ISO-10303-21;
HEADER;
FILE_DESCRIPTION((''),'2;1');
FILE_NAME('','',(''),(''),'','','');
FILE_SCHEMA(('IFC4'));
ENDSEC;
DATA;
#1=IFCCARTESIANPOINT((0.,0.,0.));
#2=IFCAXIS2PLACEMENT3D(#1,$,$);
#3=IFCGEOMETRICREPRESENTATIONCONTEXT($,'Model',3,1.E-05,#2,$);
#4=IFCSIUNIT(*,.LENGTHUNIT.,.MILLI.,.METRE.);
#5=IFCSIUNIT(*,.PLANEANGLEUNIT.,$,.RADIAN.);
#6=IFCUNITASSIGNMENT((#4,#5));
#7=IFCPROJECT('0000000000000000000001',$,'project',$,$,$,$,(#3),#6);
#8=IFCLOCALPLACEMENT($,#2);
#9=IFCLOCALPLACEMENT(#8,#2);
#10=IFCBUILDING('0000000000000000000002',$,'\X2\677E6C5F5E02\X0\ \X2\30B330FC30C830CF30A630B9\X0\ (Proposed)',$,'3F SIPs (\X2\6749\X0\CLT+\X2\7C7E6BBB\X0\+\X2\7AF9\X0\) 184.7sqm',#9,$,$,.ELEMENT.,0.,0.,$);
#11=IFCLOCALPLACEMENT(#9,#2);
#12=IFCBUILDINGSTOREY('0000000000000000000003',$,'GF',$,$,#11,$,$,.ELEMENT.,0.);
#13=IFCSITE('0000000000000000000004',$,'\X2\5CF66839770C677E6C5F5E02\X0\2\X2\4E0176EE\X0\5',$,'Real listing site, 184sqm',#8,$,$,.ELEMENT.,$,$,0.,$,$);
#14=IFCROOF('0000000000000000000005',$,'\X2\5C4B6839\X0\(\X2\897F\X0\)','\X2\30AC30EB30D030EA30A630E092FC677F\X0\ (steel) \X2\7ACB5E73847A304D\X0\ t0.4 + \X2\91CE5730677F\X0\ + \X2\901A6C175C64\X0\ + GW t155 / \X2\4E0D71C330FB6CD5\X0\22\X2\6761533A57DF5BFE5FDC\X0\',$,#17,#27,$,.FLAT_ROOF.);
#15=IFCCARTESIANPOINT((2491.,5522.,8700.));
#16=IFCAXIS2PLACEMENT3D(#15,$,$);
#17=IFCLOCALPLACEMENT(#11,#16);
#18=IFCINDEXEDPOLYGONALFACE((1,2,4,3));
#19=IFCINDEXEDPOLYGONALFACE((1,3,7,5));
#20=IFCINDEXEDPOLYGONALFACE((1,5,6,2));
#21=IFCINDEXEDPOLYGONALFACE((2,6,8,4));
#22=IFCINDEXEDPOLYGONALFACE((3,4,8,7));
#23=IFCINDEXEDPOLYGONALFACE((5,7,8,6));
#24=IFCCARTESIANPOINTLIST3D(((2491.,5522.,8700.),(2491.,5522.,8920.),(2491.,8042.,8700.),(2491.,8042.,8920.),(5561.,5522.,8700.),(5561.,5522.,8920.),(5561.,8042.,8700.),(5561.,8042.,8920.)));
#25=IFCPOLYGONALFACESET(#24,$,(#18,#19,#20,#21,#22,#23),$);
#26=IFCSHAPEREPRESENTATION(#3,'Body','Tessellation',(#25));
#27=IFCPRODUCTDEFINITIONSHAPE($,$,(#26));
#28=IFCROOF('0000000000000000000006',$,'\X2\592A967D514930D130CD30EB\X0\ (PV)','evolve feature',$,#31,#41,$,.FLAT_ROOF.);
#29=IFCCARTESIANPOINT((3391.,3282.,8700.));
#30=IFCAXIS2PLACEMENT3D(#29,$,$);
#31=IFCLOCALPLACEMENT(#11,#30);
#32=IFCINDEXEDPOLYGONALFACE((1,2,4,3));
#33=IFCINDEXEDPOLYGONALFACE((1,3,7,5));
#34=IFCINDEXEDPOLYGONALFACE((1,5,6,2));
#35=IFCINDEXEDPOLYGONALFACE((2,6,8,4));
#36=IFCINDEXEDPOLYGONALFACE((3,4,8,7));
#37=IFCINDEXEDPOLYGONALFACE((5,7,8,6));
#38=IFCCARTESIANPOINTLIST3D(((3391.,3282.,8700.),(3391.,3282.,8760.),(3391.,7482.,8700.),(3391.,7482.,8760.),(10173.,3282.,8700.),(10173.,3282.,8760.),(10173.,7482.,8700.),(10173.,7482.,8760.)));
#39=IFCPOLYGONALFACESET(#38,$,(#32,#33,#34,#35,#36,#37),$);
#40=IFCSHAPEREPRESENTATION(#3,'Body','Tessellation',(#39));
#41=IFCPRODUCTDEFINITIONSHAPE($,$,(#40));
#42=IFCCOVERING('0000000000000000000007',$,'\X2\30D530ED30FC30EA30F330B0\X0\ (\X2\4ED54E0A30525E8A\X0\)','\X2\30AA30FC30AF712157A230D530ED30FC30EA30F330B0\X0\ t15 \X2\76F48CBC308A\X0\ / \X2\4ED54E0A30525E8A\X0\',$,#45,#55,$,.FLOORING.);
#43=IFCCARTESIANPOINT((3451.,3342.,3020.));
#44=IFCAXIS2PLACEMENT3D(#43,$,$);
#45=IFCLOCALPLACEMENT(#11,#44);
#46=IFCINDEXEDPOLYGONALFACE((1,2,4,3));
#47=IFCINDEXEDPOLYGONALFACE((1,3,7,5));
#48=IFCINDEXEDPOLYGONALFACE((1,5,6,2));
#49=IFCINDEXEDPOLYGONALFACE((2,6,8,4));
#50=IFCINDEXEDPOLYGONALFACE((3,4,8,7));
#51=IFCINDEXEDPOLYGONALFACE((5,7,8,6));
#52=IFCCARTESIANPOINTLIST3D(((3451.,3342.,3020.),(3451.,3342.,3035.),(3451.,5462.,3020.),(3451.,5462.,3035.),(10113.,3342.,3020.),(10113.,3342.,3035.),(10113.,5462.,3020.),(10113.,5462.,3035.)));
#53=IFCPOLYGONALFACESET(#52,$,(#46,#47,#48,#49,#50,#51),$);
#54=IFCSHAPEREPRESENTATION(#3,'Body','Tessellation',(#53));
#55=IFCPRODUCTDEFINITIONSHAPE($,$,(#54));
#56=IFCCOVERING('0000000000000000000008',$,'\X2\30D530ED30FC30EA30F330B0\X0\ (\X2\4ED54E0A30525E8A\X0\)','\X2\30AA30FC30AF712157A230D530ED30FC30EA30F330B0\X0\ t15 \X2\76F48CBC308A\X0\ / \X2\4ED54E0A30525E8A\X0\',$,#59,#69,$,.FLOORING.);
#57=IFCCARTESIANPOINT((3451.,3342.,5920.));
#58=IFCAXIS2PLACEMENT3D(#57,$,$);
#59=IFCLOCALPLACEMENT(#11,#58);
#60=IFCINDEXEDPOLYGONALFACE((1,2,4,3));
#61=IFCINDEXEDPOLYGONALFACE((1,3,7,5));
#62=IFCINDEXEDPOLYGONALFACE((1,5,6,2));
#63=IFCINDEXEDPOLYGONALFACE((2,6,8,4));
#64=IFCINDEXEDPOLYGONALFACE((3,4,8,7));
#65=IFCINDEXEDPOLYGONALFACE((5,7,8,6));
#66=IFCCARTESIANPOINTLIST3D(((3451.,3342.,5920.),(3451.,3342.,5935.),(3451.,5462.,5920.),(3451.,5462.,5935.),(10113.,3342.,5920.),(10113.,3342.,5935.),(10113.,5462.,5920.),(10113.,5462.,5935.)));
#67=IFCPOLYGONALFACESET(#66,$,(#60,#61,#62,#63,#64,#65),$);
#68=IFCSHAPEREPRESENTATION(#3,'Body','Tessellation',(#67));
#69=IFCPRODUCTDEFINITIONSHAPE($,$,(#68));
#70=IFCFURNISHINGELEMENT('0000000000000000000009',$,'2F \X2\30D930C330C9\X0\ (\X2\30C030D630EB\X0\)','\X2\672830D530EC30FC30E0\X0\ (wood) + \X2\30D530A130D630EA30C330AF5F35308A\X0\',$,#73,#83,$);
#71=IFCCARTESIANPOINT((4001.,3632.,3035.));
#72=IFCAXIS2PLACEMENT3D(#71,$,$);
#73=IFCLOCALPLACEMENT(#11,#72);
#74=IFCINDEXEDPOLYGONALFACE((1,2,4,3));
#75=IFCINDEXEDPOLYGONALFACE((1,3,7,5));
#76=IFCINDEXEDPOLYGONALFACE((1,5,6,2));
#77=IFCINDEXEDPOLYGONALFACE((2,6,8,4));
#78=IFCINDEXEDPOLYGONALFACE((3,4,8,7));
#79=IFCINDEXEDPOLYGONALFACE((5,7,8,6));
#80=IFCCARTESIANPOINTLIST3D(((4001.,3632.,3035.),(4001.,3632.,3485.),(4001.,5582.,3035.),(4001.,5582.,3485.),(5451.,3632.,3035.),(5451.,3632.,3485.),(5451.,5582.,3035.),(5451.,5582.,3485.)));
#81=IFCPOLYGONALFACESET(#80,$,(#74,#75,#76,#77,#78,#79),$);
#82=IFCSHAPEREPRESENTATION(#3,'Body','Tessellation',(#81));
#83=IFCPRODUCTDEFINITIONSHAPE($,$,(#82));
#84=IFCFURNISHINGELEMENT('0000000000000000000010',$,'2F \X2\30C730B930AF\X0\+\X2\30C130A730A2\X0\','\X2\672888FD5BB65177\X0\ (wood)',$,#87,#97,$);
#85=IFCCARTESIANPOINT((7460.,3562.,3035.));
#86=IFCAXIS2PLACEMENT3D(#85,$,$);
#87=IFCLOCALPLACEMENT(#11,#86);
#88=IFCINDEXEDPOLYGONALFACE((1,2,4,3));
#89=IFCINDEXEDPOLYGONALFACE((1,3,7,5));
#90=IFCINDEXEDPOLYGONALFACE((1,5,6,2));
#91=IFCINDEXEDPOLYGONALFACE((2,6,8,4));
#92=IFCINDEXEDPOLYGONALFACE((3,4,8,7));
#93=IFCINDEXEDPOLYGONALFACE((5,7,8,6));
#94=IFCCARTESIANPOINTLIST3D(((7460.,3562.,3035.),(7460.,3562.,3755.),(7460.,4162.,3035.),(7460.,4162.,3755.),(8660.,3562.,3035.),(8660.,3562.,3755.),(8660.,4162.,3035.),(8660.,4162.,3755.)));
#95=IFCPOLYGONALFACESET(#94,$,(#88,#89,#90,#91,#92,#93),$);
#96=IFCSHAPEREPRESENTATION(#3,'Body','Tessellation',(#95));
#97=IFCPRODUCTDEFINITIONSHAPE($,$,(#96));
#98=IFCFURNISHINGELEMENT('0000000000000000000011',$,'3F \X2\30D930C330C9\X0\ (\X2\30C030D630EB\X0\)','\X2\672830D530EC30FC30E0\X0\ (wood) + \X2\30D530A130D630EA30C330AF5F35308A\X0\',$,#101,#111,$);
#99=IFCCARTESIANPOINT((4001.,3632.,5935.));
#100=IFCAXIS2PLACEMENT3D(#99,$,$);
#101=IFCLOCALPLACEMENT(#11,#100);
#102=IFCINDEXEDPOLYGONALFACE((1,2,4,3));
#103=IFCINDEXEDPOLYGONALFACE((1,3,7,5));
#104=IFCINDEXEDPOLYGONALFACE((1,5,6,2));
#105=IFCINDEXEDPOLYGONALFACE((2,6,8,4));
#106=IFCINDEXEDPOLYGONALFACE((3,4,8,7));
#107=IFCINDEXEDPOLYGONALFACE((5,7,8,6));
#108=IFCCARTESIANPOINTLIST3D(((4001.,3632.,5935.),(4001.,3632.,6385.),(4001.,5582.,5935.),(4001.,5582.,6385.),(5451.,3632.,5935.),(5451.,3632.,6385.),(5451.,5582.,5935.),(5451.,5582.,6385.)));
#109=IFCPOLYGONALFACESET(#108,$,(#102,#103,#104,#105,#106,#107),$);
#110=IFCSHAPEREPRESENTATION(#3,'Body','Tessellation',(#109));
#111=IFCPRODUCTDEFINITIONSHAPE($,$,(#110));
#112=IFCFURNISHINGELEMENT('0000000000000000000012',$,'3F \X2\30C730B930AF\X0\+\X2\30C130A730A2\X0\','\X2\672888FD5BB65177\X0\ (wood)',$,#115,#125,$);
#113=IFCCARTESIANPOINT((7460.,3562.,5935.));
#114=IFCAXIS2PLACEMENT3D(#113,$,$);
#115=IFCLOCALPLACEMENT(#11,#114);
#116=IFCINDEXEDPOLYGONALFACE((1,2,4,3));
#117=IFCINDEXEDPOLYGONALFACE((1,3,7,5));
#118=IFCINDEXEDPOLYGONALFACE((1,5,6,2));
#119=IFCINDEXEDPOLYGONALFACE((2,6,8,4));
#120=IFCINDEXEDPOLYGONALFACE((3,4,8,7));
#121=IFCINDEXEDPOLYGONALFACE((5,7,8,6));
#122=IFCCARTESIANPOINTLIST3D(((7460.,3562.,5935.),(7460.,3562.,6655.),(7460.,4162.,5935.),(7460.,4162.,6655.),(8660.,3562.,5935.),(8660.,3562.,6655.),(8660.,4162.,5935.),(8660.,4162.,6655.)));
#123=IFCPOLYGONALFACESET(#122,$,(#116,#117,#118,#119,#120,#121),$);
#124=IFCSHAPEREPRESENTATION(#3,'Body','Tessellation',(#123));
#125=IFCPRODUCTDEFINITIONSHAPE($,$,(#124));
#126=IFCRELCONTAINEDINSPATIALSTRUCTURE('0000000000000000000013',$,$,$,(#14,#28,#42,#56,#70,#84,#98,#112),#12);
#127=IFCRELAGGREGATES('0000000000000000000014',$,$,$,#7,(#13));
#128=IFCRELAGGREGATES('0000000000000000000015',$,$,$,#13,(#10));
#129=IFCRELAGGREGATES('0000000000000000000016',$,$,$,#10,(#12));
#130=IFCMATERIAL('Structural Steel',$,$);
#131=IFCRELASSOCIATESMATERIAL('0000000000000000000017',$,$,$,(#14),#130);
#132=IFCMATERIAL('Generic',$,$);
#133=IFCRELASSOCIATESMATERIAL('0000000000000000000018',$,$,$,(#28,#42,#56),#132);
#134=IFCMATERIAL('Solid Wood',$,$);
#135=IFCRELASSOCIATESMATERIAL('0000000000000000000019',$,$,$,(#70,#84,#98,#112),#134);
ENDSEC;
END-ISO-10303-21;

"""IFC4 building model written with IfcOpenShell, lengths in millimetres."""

from ifc_helpers import new_model, si_unit, frame, frame_2d, origin, place, context, project, spatial, rectangle, extrude, material, element, save


model = new_model("IFC4")

# Units and contexts
model_context = context("Model", 3, precision=1e-05, world=origin())
ifc_project = project(units=[si_unit("LENGTHUNIT", "METRE", prefix="MILLI"), si_unit("PLANEANGLEUNIT", "RADIAN")], contexts=[model_context])

# Site, building, storey
site_placement = place(None, origin())
site = spatial("IfcSite", under=ifc_project, at=site_placement, Name="島根県松江市2丁目5", ObjectType="Real listing site, 184sqm", CompositionType="ELEMENT", RefElevation=0.0)
building_placement = place(site_placement, origin())
building = spatial("IfcBuilding", under=site, at=building_placement, Name="松江市 コートハウス (Proposed)", ObjectType="3F SIPs (杉CLT+籾殻+竹) 184.7sqm", CompositionType="ELEMENT", ElevationOfRefHeight=0.0, ElevationOfTerrain=0.0)
storey_placement = place(building_placement, origin())
storey = spatial("IfcBuildingStorey", under=building, at=storey_placement, Name="GF", CompositionType="ELEMENT", Elevation=0.0)

# Shared definitions
ifc_material_1 = material(Name="Solid Wood")

# Roofs
ifc_material_2 = material(Name="Structural Steel")
roof_1_placement = place(storey_placement, frame((2491.0, 5522.0, 8700.0)))
element("IfcRoof", 1, at=roof_1_placement, inside=storey, material=ifc_material_2, Name="屋根(西)", Description="ガルバリウム鋼板 (steel) 立平葺き t0.4 + 野地板 + 通気層 + GW t155 / 不燃・法22条区域対応", PredefinedType="FLAT_ROOF", context=model_context, shape_type="SweptSolid", body=[
    extrude(rectangle(XDim=3070.0, YDim=2520.0, at=frame_2d((1535.0, 1260.0))), frame((2491.0, 5522.0, 8700.0)), (0.0, 0.0, 1.0), 220.0),
])
ifc_material_3 = material(Name="Generic")
roof_2_placement = place(storey_placement, frame((3391.0, 3282.0, 8700.0)))
element("IfcRoof", 2, at=roof_2_placement, inside=storey, material=ifc_material_3, Name="太陽光パネル (PV)", Description="evolve feature", PredefinedType="FLAT_ROOF", context=model_context, shape_type="SweptSolid", body=[
    extrude(rectangle(XDim=6782.0, YDim=4200.0, at=frame_2d((3391.0, 2100.0))), frame((3391.0, 3282.0, 8700.0)), (0.0, 0.0, 1.0), 60.0),
])

# Coverings
covering_1_placement = place(storey_placement, frame((3451.0, 3342.0, 3020.0)))
element("IfcCovering", 3, at=covering_1_placement, inside=storey, material=ifc_material_3, Name="フローリング (仕上げ床)", Description="オーク無垢フローリング t15 直貼り / 仕上げ床", PredefinedType="FLOORING", context=model_context, shape_type="SweptSolid", body=[
    extrude(rectangle(XDim=6662.0, YDim=2120.0, at=frame_2d((3331.0, 1060.0))), frame((3451.0, 3342.0, 3020.0)), (0.0, 0.0, 1.0), 15.0),
])
covering_2_placement = place(storey_placement, frame((3451.0, 3342.0, 5920.0)))
element("IfcCovering", 4, at=covering_2_placement, inside=storey, material=ifc_material_3, Name="フローリング (仕上げ床)", Description="オーク無垢フローリング t15 直貼り / 仕上げ床", PredefinedType="FLOORING", context=model_context, shape_type="SweptSolid", body=[
    extrude(rectangle(XDim=6662.0, YDim=2120.0, at=frame_2d((3331.0, 1060.0))), frame((3451.0, 3342.0, 5920.0)), (0.0, 0.0, 1.0), 15.0),
])

# Furnishing elements
furnishing_1_placement = place(storey_placement, frame((4001.0, 3632.0, 3035.0)))
element("IfcFurnishingElement", 5, at=furnishing_1_placement, inside=storey, material=ifc_material_1, Name="2F ベッド (ダブル)", Description="木フレーム (wood) + ファブリック張り", context=model_context, shape_type="SweptSolid", body=[
    extrude(rectangle(XDim=1450.0, YDim=1950.0, at=frame_2d((725.0, 975.0))), frame((4001.0, 3632.0, 3035.0)), (0.0, 0.0, 1.0), 450.0),
])
furnishing_2_placement = place(storey_placement, frame((7460.0, 3562.0, 3035.0)))
element("IfcFurnishingElement", 6, at=furnishing_2_placement, inside=storey, material=ifc_material_1, Name="2F デスク+チェア", Description="木製家具 (wood)", context=model_context, shape_type="SweptSolid", body=[
    extrude(rectangle(XDim=1200.0, YDim=600.0, at=frame_2d((600.0, 300.0))), frame((7460.0, 3562.0, 3035.0)), (0.0, 0.0, 1.0), 720.0),
])
furnishing_3_placement = place(storey_placement, frame((4001.0, 3632.0, 5935.0)))
element("IfcFurnishingElement", 7, at=furnishing_3_placement, inside=storey, material=ifc_material_1, Name="3F ベッド (ダブル)", Description="木フレーム (wood) + ファブリック張り", context=model_context, shape_type="SweptSolid", body=[
    extrude(rectangle(XDim=1450.0, YDim=1950.0, at=frame_2d((725.0, 975.0))), frame((4001.0, 3632.0, 5935.0)), (0.0, 0.0, 1.0), 450.0),
])
furnishing_4_placement = place(storey_placement, frame((7460.0, 3562.0, 5935.0)))
element("IfcFurnishingElement", 8, at=furnishing_4_placement, inside=storey, material=ifc_material_1, Name="3F デスク+チェア", Description="木製家具 (wood)", context=model_context, shape_type="SweptSolid", body=[
    extrude(rectangle(XDim=1200.0, YDim=600.0, at=frame_2d((600.0, 300.0))), frame((7460.0, 3562.0, 5935.0)), (0.0, 0.0, 1.0), 720.0),
])

save(model, "model.ifc")
